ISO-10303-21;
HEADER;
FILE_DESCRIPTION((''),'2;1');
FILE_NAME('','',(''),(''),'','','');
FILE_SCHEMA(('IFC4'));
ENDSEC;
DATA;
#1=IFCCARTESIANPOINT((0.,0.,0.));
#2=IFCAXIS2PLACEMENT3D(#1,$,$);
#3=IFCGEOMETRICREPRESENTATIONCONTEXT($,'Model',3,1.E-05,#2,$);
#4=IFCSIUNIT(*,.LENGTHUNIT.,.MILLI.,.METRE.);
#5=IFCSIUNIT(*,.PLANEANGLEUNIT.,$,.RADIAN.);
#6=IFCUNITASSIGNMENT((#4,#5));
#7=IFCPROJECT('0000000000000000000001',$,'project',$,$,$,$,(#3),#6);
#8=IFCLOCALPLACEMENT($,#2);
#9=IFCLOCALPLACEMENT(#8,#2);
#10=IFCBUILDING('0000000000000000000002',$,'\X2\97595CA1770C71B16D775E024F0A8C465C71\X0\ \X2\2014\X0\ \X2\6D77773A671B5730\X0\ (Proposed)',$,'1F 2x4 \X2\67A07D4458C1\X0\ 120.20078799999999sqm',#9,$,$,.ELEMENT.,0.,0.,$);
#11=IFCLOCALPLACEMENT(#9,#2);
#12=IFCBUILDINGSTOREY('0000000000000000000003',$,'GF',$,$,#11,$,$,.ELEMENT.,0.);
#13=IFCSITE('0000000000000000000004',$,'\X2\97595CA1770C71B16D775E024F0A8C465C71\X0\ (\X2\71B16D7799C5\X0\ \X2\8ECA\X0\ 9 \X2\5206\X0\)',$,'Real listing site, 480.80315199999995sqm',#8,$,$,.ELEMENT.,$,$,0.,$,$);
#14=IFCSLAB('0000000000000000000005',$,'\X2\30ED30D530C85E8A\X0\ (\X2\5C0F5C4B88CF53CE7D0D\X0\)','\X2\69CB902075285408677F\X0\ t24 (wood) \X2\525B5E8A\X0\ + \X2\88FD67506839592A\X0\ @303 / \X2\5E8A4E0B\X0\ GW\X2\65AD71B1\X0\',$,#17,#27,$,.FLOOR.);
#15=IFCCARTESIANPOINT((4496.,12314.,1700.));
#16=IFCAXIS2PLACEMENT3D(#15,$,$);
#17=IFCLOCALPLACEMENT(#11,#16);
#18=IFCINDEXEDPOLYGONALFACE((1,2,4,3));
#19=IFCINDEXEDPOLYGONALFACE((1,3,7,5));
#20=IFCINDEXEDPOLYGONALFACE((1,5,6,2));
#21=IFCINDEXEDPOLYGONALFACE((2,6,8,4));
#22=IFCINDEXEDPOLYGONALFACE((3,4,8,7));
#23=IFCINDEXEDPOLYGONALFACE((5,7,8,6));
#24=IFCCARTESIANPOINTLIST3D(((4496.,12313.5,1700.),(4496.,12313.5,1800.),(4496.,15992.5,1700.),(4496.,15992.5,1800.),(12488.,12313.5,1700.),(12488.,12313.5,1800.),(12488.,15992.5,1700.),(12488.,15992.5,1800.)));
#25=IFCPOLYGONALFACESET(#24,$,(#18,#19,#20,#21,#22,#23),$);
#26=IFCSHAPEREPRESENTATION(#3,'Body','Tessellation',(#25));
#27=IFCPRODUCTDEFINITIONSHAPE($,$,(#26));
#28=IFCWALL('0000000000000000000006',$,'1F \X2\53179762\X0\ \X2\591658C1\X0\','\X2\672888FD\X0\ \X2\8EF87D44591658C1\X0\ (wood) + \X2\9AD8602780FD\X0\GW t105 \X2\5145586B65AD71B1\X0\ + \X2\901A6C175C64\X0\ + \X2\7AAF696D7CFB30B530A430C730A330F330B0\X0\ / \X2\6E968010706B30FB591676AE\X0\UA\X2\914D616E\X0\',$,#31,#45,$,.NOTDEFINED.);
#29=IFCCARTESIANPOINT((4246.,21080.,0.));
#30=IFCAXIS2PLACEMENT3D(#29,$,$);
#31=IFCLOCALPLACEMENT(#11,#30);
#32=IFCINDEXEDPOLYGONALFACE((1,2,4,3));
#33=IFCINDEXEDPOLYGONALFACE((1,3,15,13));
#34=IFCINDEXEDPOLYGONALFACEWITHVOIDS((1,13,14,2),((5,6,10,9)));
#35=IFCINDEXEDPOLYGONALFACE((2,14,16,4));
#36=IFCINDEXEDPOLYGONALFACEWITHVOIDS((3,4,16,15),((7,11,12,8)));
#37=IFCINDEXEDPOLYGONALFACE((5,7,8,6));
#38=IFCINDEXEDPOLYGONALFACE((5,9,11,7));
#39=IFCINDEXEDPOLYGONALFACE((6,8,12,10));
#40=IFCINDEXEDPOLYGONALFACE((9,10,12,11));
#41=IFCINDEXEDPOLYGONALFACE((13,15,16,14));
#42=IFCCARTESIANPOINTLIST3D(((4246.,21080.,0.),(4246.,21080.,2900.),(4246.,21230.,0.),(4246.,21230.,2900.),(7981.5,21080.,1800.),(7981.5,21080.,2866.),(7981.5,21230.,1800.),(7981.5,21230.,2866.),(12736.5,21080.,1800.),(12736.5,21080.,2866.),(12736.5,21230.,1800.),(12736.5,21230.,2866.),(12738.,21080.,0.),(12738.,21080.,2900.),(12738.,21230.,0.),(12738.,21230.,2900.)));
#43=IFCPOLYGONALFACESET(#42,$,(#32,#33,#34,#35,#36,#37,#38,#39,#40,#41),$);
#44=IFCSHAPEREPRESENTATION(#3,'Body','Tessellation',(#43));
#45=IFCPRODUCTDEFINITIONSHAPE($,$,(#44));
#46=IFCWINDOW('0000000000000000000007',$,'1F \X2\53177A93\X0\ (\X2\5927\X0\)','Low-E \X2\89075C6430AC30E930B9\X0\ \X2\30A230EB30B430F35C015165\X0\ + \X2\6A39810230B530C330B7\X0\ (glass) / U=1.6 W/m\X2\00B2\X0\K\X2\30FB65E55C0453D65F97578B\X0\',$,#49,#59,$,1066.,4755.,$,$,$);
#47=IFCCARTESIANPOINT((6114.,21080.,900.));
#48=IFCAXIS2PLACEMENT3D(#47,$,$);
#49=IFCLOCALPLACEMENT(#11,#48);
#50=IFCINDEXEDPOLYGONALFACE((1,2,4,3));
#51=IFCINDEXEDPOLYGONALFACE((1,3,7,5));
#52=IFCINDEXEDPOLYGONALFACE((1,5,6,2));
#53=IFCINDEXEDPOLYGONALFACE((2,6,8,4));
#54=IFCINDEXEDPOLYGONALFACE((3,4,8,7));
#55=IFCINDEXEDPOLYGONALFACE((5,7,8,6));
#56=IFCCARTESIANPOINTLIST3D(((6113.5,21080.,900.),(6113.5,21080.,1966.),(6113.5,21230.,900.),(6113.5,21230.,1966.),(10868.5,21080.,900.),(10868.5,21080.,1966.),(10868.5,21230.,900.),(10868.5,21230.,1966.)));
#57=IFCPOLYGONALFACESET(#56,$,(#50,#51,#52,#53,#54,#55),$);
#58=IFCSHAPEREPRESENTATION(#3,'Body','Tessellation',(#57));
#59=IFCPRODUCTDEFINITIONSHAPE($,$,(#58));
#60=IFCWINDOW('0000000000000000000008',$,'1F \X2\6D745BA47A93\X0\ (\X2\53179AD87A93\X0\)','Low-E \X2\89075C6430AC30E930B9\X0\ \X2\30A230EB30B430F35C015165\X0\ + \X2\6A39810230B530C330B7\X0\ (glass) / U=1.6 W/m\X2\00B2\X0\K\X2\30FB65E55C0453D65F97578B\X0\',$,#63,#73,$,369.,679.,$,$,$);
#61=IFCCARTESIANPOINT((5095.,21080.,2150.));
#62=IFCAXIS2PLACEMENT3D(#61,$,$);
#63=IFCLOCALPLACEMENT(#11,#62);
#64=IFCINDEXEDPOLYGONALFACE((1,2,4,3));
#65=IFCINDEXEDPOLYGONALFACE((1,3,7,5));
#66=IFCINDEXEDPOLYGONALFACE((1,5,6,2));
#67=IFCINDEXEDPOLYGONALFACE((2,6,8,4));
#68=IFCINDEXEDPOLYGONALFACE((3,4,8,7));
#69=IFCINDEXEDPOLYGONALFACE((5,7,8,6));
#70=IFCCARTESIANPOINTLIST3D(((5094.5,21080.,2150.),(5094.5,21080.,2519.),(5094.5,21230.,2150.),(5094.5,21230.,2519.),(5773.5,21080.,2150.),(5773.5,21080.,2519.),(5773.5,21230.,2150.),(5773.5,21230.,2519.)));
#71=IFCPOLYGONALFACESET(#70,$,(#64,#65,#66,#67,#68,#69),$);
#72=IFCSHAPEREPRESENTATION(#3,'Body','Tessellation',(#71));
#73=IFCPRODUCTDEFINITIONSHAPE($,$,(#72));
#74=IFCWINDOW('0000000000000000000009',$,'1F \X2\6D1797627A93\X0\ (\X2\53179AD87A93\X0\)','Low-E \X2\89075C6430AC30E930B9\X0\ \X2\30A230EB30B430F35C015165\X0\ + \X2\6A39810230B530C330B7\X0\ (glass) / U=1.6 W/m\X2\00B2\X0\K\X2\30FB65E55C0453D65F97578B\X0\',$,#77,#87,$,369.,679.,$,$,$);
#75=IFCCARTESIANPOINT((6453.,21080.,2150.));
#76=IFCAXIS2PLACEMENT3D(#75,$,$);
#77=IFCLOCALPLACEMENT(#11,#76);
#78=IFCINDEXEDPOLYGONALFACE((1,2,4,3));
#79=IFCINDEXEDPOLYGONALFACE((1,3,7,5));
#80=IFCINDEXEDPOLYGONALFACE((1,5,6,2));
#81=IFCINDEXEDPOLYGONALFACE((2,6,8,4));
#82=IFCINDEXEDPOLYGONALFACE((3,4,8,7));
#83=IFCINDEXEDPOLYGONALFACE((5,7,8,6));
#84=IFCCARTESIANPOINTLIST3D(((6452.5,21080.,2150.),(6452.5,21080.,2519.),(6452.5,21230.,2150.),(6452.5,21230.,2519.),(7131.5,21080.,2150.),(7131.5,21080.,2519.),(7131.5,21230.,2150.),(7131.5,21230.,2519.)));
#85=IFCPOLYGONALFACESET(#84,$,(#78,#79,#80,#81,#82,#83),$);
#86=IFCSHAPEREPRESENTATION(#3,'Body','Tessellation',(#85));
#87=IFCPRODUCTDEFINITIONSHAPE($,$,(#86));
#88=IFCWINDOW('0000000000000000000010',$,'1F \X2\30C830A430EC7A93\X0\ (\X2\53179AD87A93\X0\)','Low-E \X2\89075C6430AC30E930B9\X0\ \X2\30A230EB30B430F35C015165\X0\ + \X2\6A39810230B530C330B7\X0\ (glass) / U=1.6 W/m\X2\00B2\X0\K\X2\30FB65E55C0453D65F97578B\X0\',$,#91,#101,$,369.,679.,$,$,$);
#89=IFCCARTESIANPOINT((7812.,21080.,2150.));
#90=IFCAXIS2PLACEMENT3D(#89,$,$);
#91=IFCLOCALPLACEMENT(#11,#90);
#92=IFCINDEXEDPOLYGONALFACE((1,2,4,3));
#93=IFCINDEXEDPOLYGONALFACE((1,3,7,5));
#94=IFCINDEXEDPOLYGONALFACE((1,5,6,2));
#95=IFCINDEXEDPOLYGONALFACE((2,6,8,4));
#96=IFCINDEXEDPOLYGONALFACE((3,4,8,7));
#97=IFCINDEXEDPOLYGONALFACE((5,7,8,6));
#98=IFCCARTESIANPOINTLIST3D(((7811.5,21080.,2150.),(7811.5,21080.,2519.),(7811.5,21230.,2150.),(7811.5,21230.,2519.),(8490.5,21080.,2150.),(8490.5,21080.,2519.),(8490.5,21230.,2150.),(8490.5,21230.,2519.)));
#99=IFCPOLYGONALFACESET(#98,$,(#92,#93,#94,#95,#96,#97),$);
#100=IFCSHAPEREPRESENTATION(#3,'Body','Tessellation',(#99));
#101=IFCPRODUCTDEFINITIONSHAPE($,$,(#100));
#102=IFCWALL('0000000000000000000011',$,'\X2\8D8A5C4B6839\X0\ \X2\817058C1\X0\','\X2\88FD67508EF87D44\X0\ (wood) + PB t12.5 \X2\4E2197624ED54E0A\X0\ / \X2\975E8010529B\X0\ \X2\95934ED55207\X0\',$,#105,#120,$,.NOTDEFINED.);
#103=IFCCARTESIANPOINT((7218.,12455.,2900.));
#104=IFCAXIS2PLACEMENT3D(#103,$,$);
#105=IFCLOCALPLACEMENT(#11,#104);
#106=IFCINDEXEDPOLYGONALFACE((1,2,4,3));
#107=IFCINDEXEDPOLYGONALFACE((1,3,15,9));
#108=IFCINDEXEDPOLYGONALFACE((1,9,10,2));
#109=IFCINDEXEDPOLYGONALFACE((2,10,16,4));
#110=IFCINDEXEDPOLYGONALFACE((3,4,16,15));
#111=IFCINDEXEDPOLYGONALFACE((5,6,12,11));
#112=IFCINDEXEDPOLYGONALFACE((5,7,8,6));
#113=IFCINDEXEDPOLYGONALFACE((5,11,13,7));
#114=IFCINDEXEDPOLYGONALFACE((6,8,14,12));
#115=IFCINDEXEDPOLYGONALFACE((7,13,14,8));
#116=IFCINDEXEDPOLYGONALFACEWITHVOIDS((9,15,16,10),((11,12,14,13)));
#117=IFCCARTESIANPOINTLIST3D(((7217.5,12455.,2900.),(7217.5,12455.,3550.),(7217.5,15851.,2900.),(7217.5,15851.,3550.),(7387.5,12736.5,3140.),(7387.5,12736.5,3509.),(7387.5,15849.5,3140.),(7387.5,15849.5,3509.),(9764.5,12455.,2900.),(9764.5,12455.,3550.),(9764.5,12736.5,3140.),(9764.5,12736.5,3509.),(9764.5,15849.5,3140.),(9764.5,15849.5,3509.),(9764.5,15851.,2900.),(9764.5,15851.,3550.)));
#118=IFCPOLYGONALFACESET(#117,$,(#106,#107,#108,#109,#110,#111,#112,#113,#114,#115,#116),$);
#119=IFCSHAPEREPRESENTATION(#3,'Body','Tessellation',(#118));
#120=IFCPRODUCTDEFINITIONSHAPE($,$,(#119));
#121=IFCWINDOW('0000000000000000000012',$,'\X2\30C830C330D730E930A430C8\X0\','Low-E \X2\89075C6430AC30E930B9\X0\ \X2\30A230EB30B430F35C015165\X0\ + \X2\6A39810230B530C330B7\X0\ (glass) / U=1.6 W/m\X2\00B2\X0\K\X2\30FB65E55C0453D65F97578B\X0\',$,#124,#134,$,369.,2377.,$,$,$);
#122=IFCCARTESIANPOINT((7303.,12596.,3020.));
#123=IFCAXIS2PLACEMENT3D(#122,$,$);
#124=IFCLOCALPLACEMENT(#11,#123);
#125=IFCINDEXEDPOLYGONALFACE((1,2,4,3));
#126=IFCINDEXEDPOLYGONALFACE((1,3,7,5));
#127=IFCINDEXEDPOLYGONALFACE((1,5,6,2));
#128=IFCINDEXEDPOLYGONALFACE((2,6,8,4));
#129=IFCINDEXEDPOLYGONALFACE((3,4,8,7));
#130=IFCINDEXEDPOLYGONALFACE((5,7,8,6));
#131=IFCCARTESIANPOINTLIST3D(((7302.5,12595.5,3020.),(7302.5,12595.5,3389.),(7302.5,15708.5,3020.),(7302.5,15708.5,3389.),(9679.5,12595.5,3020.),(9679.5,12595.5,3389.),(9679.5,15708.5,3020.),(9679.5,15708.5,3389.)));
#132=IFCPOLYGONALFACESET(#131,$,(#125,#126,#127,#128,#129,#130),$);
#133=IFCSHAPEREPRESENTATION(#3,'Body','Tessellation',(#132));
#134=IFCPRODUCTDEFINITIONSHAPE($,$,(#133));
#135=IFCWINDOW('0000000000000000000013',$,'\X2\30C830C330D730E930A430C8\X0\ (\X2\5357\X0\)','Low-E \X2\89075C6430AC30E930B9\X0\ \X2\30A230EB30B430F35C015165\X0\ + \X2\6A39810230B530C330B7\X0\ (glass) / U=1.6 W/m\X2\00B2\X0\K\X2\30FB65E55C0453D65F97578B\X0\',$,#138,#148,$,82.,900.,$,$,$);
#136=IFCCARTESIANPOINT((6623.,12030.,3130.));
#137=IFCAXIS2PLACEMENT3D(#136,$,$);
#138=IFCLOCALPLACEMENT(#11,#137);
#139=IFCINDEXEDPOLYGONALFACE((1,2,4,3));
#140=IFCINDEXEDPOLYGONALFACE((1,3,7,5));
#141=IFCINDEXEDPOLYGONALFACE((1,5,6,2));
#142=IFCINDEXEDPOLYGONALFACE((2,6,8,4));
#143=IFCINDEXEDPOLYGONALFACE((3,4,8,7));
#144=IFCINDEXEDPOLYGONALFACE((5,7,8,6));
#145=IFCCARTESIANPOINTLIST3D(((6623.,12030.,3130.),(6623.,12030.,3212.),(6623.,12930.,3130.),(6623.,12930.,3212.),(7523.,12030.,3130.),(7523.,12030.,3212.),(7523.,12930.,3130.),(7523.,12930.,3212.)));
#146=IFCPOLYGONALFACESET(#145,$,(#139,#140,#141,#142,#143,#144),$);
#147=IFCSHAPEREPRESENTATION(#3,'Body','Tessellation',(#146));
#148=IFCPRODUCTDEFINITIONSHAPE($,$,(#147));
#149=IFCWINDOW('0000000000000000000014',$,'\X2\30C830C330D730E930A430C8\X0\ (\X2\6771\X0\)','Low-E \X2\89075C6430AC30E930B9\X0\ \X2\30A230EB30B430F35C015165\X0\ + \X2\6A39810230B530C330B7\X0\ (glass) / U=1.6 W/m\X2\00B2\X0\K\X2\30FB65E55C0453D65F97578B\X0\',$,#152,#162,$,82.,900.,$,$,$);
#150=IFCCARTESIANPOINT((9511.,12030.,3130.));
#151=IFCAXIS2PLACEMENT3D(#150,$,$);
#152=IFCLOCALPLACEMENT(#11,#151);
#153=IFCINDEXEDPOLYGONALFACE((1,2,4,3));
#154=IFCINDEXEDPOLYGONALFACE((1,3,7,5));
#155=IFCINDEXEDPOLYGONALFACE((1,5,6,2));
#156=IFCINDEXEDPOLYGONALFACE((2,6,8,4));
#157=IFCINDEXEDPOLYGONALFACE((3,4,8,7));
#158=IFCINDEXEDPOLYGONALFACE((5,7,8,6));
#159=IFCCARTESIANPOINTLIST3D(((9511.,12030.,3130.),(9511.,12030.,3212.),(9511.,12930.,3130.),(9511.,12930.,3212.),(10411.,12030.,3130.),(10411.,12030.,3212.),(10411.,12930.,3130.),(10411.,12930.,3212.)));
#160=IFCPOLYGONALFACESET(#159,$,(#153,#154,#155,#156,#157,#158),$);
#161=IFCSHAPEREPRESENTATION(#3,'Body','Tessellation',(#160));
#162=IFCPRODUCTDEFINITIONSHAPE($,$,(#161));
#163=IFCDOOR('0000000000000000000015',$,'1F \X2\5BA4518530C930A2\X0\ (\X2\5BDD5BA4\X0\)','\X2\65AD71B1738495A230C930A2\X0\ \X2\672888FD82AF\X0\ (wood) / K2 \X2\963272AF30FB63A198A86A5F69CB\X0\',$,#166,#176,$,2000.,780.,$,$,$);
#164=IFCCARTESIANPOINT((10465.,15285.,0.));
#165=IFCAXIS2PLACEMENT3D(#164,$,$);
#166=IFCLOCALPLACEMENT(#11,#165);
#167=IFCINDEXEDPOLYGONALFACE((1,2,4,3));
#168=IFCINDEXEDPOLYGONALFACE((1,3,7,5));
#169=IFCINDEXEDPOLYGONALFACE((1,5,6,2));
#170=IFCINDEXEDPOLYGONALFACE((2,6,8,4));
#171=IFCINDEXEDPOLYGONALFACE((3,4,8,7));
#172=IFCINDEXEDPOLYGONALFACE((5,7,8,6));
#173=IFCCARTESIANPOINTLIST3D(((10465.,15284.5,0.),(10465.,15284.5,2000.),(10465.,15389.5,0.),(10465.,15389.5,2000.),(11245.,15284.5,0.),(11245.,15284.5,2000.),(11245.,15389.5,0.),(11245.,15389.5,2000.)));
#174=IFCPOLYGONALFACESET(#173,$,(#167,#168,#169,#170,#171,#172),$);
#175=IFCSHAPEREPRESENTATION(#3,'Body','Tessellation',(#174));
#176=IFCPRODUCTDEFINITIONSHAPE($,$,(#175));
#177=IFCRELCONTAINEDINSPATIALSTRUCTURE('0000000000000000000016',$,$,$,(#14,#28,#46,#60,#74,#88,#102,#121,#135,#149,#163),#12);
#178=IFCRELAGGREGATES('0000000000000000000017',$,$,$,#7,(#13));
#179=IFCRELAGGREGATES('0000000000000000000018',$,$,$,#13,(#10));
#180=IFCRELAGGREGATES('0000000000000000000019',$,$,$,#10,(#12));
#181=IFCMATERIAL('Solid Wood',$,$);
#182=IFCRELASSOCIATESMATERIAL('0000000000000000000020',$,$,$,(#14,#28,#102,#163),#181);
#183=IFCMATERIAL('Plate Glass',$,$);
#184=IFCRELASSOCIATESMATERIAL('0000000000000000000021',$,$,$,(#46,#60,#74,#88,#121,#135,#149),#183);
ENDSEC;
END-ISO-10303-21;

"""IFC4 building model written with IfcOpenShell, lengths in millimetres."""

from ifc_helpers import new_model, si_unit, frame, frame_2d, origin, place, context, project, spatial, rectangle, extrude, material, element, fill, save


model = new_model("IFC4")

# Units and contexts
model_context = context("Model", 3, precision=1e-05, world=origin())
ifc_project = project(units=[si_unit("LENGTHUNIT", "METRE", prefix="MILLI"), si_unit("PLANEANGLEUNIT", "RADIAN")], contexts=[model_context])

# Site, building, storey
site_placement = place(None, origin())
site = spatial("IfcSite", under=ifc_project, at=site_placement, Name="静岡県熱海市伊豆山 (熱海駅 車 9 分)", ObjectType="Real listing site, 480.80315199999995sqm", CompositionType="ELEMENT", RefElevation=0.0)
building_placement = place(site_placement, origin())
building = spatial("IfcBuilding", under=site, at=building_placement, Name="静岡県熱海市伊豆山 — 海眺望地 (Proposed)", ObjectType="1F 2x4 枠組壁 120.20078799999999sqm", CompositionType="ELEMENT", ElevationOfRefHeight=0.0, ElevationOfTerrain=0.0)
storey_placement = place(building_placement, origin())
storey = spatial("IfcBuildingStorey", under=building, at=storey_placement, Name="GF", CompositionType="ELEMENT", Elevation=0.0)

# Slab
ifc_material_1 = material(Name="Solid Wood")
slab_placement = place(storey_placement, frame((4496.0, 12314.0, 1700.0)))
element("IfcSlab", 1, at=slab_placement, inside=storey, material=ifc_material_1, Name="ロフト床 (小屋裏収納)", Description="構造用合板 t24 (wood) 剛床 + 製材根太 @303 / 床下 GW断熱", PredefinedType="FLOOR", context=model_context, shape_type="SweptSolid", body=[
    extrude(rectangle(XDim=7992.0, YDim=3679.0, at=frame_2d((3996.0, 1839.0))), frame((4496.0, 12314.0, 1700.0)), (0.0, 0.0, 1.0), 100.0),
])

# Wall, openings, windows
wall_1_placement = place(storey_placement, frame((4246.0, 21080.0, 0.0)))
wall_1 = element("IfcWall", 2, at=wall_1_placement, inside=storey, material=ifc_material_1, Name="1F 北面 外壁", Description="木製 軸組外壁 (wood) + 高性能GW t105 充填断熱 + 通気層 + 窯業系サイディング / 準耐火・外皮UA配慮", PredefinedType="NOTDEFINED", context=model_context, shape_type="SweptSolid", body=[
    extrude(rectangle(XDim=8492.0, YDim=150.0, at=frame_2d((4246.0, 75.0))), frame((4246.0, 21080.0, 0.0)), (0.0, 0.0, 1.0), 2900.0),
])
opening_1_placement = place(storey_placement, frame((6114.0, 21080.0, 900.0)))
opening_1 = element("IfcOpeningElement", 3, at=opening_1_placement, cuts=wall_1, PredefinedType="NOTDEFINED", context=model_context, shape_type="SweptSolid", body=[
    extrude(rectangle(XDim=4755.0, YDim=150.0, at=frame_2d((2377.0, 75.0))), frame((6114.0, 21080.0, 900.0)), (0.0, 0.0, 1.0), 1066.0),
])
opening_2_placement = place(storey_placement, frame((5095.0, 21080.0, 2150.0)))
opening_2 = element("IfcOpeningElement", 4, at=opening_2_placement, cuts=wall_1, PredefinedType="NOTDEFINED", context=model_context, shape_type="SweptSolid", body=[
    extrude(rectangle(XDim=679.0, YDim=150.0, at=frame_2d((339.0, 75.0))), frame((5095.0, 21080.0, 2150.0)), (0.0, 0.0, 1.0), 369.0),
])
opening_3_placement = place(storey_placement, frame((6453.0, 21080.0, 2150.0)))
opening_3 = element("IfcOpeningElement", 5, at=opening_3_placement, cuts=wall_1, PredefinedType="NOTDEFINED", context=model_context, shape_type="SweptSolid", body=[
    extrude(rectangle(XDim=679.0, YDim=150.0, at=frame_2d((339.0, 75.0))), frame((6453.0, 21080.0, 2150.0)), (0.0, 0.0, 1.0), 369.0),
])
opening_4_placement = place(storey_placement, frame((7812.0, 21080.0, 2150.0)))
opening_4 = element("IfcOpeningElement", 6, at=opening_4_placement, cuts=wall_1, PredefinedType="NOTDEFINED", context=model_context, shape_type="SweptSolid", body=[
    extrude(rectangle(XDim=679.0, YDim=150.0, at=frame_2d((339.0, 75.0))), frame((7812.0, 21080.0, 2150.0)), (0.0, 0.0, 1.0), 369.0),
])
ifc_material_2 = material(Name="Plate Glass")
window_1_placement = place(storey_placement, frame((6114.0, 21080.0, 900.0)))
window_1 = element("IfcWindow", 7, at=window_1_placement, inside=storey, material=ifc_material_2, Name="1F 北窓 (大)", Description="Low-E 複層ガラス アルゴン封入 + 樹脂サッシ (glass) / U=1.6 W/m²K・日射取得型", OverallHeight=1066.0, OverallWidth=4755.0, context=model_context, shape_type="SweptSolid", body=[
    extrude(rectangle(XDim=4755.0, YDim=150.0, at=frame_2d((2377.0, 75.0))), frame((6114.0, 21080.0, 900.0)), (0.0, 0.0, 1.0), 1066.0),
])
fill(opening_1, window_1)
window_2_placement = place(storey_placement, frame((5095.0, 21080.0, 2150.0)))
window_2 = element("IfcWindow", 8, at=window_2_placement, inside=storey, material=ifc_material_2, Name="1F 浴室窓 (北高窓)", Description="Low-E 複層ガラス アルゴン封入 + 樹脂サッシ (glass) / U=1.6 W/m²K・日射取得型", OverallHeight=369.0, OverallWidth=679.0, context=model_context, shape_type="SweptSolid", body=[
    extrude(rectangle(XDim=679.0, YDim=150.0, at=frame_2d((339.0, 75.0))), frame((5095.0, 21080.0, 2150.0)), (0.0, 0.0, 1.0), 369.0),
])
fill(opening_2, window_2)
window_3_placement = place(storey_placement, frame((6453.0, 21080.0, 2150.0)))
window_3 = element("IfcWindow", 9, at=window_3_placement, inside=storey, material=ifc_material_2, Name="1F 洗面窓 (北高窓)", Description="Low-E 複層ガラス アルゴン封入 + 樹脂サッシ (glass) / U=1.6 W/m²K・日射取得型", OverallHeight=369.0, OverallWidth=679.0, context=model_context, shape_type="SweptSolid", body=[
    extrude(rectangle(XDim=679.0, YDim=150.0, at=frame_2d((339.0, 75.0))), frame((6453.0, 21080.0, 2150.0)), (0.0, 0.0, 1.0), 369.0),
])
fill(opening_3, window_3)
window_4_placement = place(storey_placement, frame((7812.0, 21080.0, 2150.0)))
window_4 = element("IfcWindow", 10, at=window_4_placement, inside=storey, material=ifc_material_2, Name="1F トイレ窓 (北高窓)", Description="Low-E 複層ガラス アルゴン封入 + 樹脂サッシ (glass) / U=1.6 W/m²K・日射取得型", OverallHeight=369.0, OverallWidth=679.0, context=model_context, shape_type="SweptSolid", body=[
    extrude(rectangle(XDim=679.0, YDim=150.0, at=frame_2d((339.0, 75.0))), frame((7812.0, 21080.0, 2150.0)), (0.0, 0.0, 1.0), 369.0),
])
fill(opening_4, window_4)

# Wall, openings, windows
wall_2_placement = place(storey_placement, frame((7218.0, 12455.0, 2900.0)))
wall_2 = element("IfcWall", 11, at=wall_2_placement, inside=storey, material=ifc_material_1, Name="越屋根 腰壁", Description="製材軸組 (wood) + PB t12.5 両面仕上 / 非耐力 間仕切", PredefinedType="NOTDEFINED", context=model_context, shape_type="SweptSolid", body=[
    extrude(rectangle(XDim=2547.0, YDim=3396.0, at=frame_2d((1273.0, 1698.0))), frame((7218.0, 12455.0, 2900.0)), (0.0, 0.0, 1.0), 650.0),
])
opening_5_placement = place(storey_placement, frame((7303.0, 12596.0, 3020.0)))
opening_5 = element("IfcOpeningElement", 12, at=opening_5_placement, cuts=wall_2, PredefinedType="NOTDEFINED", context=model_context, shape_type="SweptSolid", body=[
    extrude(rectangle(XDim=2377.0, YDim=3113.0, at=frame_2d((1188.0, 1556.0))), frame((7303.0, 12596.0, 3020.0)), (0.0, 0.0, 1.0), 369.0),
])
opening_6_placement = place(storey_placement, frame((6623.0, 12030.0, 3130.0)))
opening_6 = element("IfcOpeningElement", 13, at=opening_6_placement, cuts=wall_2, PredefinedType="NOTDEFINED", context=model_context, shape_type="SweptSolid", body=[
    extrude(rectangle(XDim=900.0, YDim=900.0, at=frame_2d((450.0, 450.0))), frame((6623.0, 12030.0, 3130.0)), (0.0, 0.0, 1.0), 82.0),
])
opening_7_placement = place(storey_placement, frame((9511.0, 12030.0, 3130.0)))
opening_7 = element("IfcOpeningElement", 14, at=opening_7_placement, cuts=wall_2, PredefinedType="NOTDEFINED", context=model_context, shape_type="SweptSolid", body=[
    extrude(rectangle(XDim=900.0, YDim=900.0, at=frame_2d((450.0, 450.0))), frame((9511.0, 12030.0, 3130.0)), (0.0, 0.0, 1.0), 82.0),
])
window_5_placement = place(storey_placement, frame((7303.0, 12596.0, 3020.0)))
window_5 = element("IfcWindow", 15, at=window_5_placement, inside=storey, material=ifc_material_2, Name="トップライト", Description="Low-E 複層ガラス アルゴン封入 + 樹脂サッシ (glass) / U=1.6 W/m²K・日射取得型", OverallHeight=369.0, OverallWidth=2377.0, context=model_context, shape_type="SweptSolid", body=[
    extrude(rectangle(XDim=2377.0, YDim=3113.0, at=frame_2d((1188.0, 1556.0))), frame((7303.0, 12596.0, 3020.0)), (0.0, 0.0, 1.0), 369.0),
])
fill(opening_5, window_5)
window_6_placement = place(storey_placement, frame((6623.0, 12030.0, 3130.0)))
window_6 = element("IfcWindow", 16, at=window_6_placement, inside=storey, material=ifc_material_2, Name="トップライト (南)", Description="Low-E 複層ガラス アルゴン封入 + 樹脂サッシ (glass) / U=1.6 W/m²K・日射取得型", OverallHeight=82.0, OverallWidth=900.0, context=model_context, shape_type="SweptSolid", body=[
    extrude(rectangle(XDim=900.0, YDim=900.0, at=frame_2d((450.0, 450.0))), frame((6623.0, 12030.0, 3130.0)), (0.0, 0.0, 1.0), 82.0),
])
fill(opening_6, window_6)
window_7_placement = place(storey_placement, frame((9511.0, 12030.0, 3130.0)))
window_7 = element("IfcWindow", 17, at=window_7_placement, inside=storey, material=ifc_material_2, Name="トップライト (東)", Description="Low-E 複層ガラス アルゴン封入 + 樹脂サッシ (glass) / U=1.6 W/m²K・日射取得型", OverallHeight=82.0, OverallWidth=900.0, context=model_context, shape_type="SweptSolid", body=[
    extrude(rectangle(XDim=900.0, YDim=900.0, at=frame_2d((450.0, 450.0))), frame((9511.0, 12030.0, 3130.0)), (0.0, 0.0, 1.0), 82.0),
])
fill(opening_7, window_7)

# Door
door_1_placement = place(storey_placement, frame((10465.0, 15285.0, 0.0)))
element("IfcDoor", 18, at=door_1_placement, inside=storey, material=ifc_material_1, Name="1F 室内ドア (寝室)", Description="断熱玄関ドア 木製芯 (wood) / K2 防犯・採風機構", OverallHeight=2000.0, OverallWidth=780.0, context=model_context, shape_type="SweptSolid", body=[
    extrude(rectangle(XDim=780.0, YDim=105.0, at=frame_2d((390.0, 52.0))), frame((10465.0, 15285.0, 0.0)), (0.0, 0.0, 1.0), 2000.0),
])

save(model, "model.ifc")
